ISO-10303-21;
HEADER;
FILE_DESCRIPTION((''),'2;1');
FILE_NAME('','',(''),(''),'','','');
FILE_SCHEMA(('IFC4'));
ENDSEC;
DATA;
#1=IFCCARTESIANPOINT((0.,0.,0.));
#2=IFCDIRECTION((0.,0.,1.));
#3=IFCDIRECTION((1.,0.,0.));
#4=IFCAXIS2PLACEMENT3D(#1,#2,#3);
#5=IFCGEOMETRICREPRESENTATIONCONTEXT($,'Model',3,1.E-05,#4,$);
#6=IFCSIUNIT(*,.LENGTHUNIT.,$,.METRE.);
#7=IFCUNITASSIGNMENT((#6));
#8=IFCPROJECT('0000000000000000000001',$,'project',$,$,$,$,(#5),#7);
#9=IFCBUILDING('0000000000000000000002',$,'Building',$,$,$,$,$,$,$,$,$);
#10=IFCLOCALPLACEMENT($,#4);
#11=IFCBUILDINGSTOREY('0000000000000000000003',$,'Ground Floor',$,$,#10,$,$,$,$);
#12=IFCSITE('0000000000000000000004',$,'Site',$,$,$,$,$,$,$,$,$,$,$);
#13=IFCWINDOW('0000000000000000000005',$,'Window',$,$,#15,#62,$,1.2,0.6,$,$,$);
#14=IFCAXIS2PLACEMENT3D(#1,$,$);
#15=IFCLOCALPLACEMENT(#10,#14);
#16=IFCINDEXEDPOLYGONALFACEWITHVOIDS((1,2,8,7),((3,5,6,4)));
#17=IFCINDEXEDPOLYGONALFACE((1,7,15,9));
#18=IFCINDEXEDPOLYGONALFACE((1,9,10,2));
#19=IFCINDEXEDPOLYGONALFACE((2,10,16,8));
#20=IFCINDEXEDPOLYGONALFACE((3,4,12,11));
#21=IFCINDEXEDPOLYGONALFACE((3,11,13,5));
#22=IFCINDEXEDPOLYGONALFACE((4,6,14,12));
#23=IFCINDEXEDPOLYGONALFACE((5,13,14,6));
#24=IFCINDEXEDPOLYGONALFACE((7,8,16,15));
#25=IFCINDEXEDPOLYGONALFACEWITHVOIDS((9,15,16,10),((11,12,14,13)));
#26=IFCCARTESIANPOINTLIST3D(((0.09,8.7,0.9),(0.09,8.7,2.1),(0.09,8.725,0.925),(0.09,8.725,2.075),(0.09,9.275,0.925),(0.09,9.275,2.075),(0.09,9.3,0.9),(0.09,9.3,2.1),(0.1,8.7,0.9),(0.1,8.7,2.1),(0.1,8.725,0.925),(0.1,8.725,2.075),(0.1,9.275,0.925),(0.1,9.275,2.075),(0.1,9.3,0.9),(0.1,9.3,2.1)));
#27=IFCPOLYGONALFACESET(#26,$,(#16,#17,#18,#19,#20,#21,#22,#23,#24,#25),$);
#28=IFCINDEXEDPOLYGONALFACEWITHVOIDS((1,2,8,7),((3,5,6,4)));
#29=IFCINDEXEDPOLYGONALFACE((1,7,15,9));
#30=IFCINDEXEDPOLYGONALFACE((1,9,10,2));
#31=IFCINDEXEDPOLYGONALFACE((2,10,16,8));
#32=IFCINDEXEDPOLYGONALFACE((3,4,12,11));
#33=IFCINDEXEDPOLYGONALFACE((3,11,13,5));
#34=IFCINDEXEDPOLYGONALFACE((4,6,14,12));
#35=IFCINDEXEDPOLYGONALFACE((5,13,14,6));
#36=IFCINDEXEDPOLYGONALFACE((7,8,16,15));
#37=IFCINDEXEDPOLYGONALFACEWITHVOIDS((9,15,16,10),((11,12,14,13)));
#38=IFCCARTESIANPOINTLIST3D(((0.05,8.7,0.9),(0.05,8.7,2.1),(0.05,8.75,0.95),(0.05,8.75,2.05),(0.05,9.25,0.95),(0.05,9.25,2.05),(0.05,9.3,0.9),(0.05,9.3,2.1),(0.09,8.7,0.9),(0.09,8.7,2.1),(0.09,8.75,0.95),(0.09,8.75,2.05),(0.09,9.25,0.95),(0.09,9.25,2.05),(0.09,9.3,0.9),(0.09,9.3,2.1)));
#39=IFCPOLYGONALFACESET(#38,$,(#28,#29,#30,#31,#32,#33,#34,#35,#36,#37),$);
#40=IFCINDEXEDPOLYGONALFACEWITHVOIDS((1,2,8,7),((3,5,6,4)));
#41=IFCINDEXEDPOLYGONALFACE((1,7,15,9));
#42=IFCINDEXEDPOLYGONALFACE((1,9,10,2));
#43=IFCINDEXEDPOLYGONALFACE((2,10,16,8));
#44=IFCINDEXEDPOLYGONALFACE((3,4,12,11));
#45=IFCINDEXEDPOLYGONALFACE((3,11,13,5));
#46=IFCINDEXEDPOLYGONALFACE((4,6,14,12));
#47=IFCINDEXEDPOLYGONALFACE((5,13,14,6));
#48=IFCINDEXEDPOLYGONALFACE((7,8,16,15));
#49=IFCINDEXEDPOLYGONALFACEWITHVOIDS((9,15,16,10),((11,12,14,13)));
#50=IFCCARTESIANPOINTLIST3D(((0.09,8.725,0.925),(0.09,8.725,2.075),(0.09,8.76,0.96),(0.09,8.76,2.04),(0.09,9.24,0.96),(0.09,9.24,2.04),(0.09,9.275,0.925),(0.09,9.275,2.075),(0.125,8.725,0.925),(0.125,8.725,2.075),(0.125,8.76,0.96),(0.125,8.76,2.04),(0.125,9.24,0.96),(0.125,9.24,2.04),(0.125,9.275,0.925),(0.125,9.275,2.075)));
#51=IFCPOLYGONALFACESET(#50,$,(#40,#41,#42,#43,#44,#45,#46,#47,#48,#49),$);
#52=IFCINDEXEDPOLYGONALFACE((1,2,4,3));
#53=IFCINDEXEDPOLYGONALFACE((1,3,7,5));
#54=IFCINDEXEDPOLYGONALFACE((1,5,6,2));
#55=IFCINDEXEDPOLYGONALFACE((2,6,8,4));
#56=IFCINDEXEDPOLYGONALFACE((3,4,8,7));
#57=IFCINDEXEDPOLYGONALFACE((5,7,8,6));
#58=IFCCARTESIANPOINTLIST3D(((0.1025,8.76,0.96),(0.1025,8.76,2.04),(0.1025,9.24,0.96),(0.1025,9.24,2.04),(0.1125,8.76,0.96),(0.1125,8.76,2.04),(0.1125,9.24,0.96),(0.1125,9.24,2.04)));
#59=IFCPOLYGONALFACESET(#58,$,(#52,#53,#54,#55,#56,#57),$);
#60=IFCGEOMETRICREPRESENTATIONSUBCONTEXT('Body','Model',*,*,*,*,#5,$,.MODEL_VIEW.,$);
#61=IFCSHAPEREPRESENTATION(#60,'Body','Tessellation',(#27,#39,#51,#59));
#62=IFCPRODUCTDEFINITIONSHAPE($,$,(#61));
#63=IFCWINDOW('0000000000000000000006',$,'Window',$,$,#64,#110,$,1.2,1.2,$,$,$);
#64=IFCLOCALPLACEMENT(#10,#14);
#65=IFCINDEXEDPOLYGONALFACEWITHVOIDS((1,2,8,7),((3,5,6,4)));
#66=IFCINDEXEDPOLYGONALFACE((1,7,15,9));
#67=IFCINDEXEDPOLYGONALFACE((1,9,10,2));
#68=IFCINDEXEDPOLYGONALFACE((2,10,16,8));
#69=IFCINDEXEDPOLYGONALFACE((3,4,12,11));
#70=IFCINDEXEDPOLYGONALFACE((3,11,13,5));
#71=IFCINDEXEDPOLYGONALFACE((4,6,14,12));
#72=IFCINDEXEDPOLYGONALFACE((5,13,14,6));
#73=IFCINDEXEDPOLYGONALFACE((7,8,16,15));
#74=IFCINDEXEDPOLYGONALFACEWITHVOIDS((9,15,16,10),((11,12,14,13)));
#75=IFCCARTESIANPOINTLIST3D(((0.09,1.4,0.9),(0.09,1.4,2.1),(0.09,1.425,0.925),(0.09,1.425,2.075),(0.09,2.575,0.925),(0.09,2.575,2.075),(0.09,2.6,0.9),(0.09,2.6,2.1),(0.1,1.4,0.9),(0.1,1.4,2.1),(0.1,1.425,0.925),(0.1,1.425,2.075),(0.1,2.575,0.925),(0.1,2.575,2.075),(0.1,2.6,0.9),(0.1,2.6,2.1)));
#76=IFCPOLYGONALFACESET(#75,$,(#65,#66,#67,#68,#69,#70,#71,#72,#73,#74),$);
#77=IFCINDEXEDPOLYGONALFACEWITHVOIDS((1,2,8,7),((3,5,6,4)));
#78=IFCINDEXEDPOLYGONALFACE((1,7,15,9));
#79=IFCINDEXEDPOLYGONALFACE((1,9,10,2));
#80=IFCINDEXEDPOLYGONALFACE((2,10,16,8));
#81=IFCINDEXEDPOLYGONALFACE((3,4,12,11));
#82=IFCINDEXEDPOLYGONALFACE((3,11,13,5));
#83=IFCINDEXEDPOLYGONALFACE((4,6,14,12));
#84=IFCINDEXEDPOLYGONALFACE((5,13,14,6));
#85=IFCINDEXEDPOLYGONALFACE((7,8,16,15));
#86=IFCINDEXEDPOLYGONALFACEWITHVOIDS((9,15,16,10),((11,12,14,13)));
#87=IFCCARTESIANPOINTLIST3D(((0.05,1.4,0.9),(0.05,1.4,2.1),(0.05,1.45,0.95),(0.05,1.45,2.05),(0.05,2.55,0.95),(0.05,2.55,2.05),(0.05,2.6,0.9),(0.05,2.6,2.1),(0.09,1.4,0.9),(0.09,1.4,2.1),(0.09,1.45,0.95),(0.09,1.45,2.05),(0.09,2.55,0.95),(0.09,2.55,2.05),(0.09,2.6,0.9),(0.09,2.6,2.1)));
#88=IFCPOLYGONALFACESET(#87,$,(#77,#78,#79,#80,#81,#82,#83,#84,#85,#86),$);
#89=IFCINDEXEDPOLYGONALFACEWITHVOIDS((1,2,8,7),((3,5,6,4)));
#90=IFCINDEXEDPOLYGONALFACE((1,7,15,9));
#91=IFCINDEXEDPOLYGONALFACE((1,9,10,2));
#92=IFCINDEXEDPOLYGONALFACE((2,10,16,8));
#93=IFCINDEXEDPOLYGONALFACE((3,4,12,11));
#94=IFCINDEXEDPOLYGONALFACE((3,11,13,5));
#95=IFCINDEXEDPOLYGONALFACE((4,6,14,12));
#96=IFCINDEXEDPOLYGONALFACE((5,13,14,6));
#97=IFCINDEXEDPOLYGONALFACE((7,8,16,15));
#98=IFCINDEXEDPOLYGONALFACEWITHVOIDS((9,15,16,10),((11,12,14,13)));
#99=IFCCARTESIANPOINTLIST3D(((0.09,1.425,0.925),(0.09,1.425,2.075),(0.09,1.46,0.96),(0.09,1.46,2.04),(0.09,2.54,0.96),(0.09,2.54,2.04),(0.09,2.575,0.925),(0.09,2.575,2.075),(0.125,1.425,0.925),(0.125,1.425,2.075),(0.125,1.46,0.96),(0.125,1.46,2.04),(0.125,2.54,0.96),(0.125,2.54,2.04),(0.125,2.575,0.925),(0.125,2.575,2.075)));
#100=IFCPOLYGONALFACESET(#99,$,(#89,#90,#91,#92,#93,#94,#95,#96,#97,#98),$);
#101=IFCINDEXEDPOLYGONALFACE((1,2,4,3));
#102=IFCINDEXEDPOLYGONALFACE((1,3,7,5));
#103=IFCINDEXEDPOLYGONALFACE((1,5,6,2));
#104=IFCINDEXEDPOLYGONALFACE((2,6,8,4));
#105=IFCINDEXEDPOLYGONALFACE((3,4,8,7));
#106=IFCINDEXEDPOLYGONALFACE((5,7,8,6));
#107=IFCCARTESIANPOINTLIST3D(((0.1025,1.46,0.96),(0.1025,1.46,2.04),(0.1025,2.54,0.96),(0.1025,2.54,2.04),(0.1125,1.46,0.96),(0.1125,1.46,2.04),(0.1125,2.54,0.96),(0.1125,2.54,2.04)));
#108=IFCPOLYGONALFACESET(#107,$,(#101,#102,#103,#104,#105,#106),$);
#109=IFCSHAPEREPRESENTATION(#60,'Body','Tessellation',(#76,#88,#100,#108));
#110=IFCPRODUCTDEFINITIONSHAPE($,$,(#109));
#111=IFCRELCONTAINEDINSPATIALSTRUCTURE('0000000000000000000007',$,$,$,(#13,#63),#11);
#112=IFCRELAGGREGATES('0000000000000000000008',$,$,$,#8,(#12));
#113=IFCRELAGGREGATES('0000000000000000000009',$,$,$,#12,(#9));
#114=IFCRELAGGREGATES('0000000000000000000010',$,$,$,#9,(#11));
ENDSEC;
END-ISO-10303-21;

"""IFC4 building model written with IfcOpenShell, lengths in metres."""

from ifc_helpers import new_model, si_unit, frame, origin_with_axes, place, context, subcontext, project, spatial, line, indexed_curve, outline, extrude, element, save


model = new_model("IFC4")

# Units and contexts
model_context = context("Model", 3, precision=1e-05, world=origin_with_axes())
body_context = subcontext(model_context, "Body", "Model", "MODEL_VIEW")
ifc_project = project(units=[si_unit("LENGTHUNIT", "METRE")], contexts=[model_context])

# Site, building, storey
site = spatial("IfcSite", under=ifc_project, Name="Site")
building = spatial("IfcBuilding", under=site, Name="Building")
storey_placement = place(None, origin_with_axes())
storey = spatial("IfcBuildingStorey", under=building, at=storey_placement, Name="Ground Floor")

# Windows
for number, where, z_axis, x_axis, name in (
    (1, (0.0, 9.3, 0.9), (0.0, 0.0, 1.0), (0.0, -1.0, 0.0), "Window"),
):
    element("IfcWindow", number, at=place(storey_placement, frame(where, z_axis=z_axis, x_axis=x_axis)), inside=storey, Name=name, OverallHeight=1.2, OverallWidth=0.6, context=body_context, shape_type="SweptSolid", body=[
        extrude(outline(indexed_curve([(0.0, 0.0), (0.6, 0.0), (0.6, 1.2), (0.0, 1.2)], segments=[line(1, 2, 3, 4, 1)]), holes=[indexed_curve([(0.025, 0.025), (0.575, 0.025), (0.575, 1.175), (0.025, 1.175)], segments=[line(1, 2, 3, 4, 1)])]), frame((0.0, 0.09, 0.0), z_axis=(0.0, -1.0, 0.0), x_axis=(1.0, 0.0, 0.0)), (0.0, 0.0, -1.0), 0.01),
        extrude(outline(indexed_curve([(0.0, 0.0), (0.6, 0.0), (0.6, 1.2), (0.0, 1.2)], segments=[line(1, 2, 3, 4, 1)]), holes=[indexed_curve([(0.05, 0.05), (0.55, 0.05), (0.55, 1.15), (0.05, 1.15)], segments=[line(1, 2, 3, 4, 1)])]), frame((0.0, 0.05, 0.0), z_axis=(0.0, -1.0, 0.0), x_axis=(1.0, 0.0, 0.0)), (0.0, 0.0, -1.0), 0.04),
        extrude(outline(indexed_curve([(0.0, 0.0), (0.55, 0.0), (0.55, 1.15), (0.0, 1.15)], segments=[line(1, 2, 3, 4, 1)]), holes=[indexed_curve([(0.035, 0.035), (0.515, 0.035), (0.515, 1.115), (0.035, 1.115)], segments=[line(1, 2, 3, 4, 1)])]), frame((0.025, 0.09, 0.025), z_axis=(0.0, -1.0, 0.0), x_axis=(1.0, 0.0, 0.0)), (0.0, 0.0, -1.0), 0.035),
        extrude(outline(indexed_curve([(0.035, 0.035), (0.515, 0.035), (0.515, 1.115), (0.035, 1.115)], segments=[line(1, 2, 3, 4, 1)])), frame((0.025, 0.1025, 0.025), z_axis=(0.0, -1.0, 0.0), x_axis=(1.0, 0.0, 0.0)), (0.0, 0.0, -1.0), 0.01),
    ])
window_1_placement = place(storey_placement, frame((0.0, 2.6, 0.9), z_axis=(0.0, 0.0, 1.0), x_axis=(0.0, -1.0, 0.0)))
element("IfcWindow", 2, at=window_1_placement, inside=storey, Name="Window", OverallHeight=1.2, OverallWidth=1.2, context=body_context, shape_type="SweptSolid", body=[
    extrude(outline(indexed_curve([(0.0, 0.0), (1.2, 0.0), (1.2, 1.2), (0.0, 1.2)], segments=[line(1, 2, 3, 4, 1)]), holes=[indexed_curve([(0.025, 0.025), (1.175, 0.025), (1.175, 1.175), (0.025, 1.175)], segments=[line(1, 2, 3, 4, 1)])]), frame((0.0, 0.09, 0.0), z_axis=(0.0, -1.0, 0.0), x_axis=(1.0, 0.0, 0.0)), (0.0, 0.0, -1.0), 0.01),
    extrude(outline(indexed_curve([(0.0, 0.0), (1.2, 0.0), (1.2, 1.2), (0.0, 1.2)], segments=[line(1, 2, 3, 4, 1)]), holes=[indexed_curve([(0.05, 0.05), (1.15, 0.05), (1.15, 1.15), (0.05, 1.15)], segments=[line(1, 2, 3, 4, 1)])]), frame((0.0, 0.05, 0.0), z_axis=(0.0, -1.0, 0.0), x_axis=(1.0, 0.0, 0.0)), (0.0, 0.0, -1.0), 0.04),
    extrude(outline(indexed_curve([(0.0, 0.0), (1.15, 0.0), (1.15, 1.15), (0.0, 1.15)], segments=[line(1, 2, 3, 4, 1)]), holes=[indexed_curve([(0.035, 0.035), (1.115, 0.035), (1.115, 1.115), (0.035, 1.115)], segments=[line(1, 2, 3, 4, 1)])]), frame((0.025, 0.09, 0.025), z_axis=(0.0, -1.0, 0.0), x_axis=(1.0, 0.0, 0.0)), (0.0, 0.0, -1.0), 0.035),
    extrude(outline(indexed_curve([(0.035, 0.035), (1.115, 0.035), (1.115, 1.115), (0.035, 1.115)], segments=[line(1, 2, 3, 4, 1)])), frame((0.025, 0.1025, 0.025), z_axis=(0.0, -1.0, 0.0), x_axis=(1.0, 0.0, 0.0)), (0.0, 0.0, -1.0), 0.01),
])

save(model, "model.ifc")
